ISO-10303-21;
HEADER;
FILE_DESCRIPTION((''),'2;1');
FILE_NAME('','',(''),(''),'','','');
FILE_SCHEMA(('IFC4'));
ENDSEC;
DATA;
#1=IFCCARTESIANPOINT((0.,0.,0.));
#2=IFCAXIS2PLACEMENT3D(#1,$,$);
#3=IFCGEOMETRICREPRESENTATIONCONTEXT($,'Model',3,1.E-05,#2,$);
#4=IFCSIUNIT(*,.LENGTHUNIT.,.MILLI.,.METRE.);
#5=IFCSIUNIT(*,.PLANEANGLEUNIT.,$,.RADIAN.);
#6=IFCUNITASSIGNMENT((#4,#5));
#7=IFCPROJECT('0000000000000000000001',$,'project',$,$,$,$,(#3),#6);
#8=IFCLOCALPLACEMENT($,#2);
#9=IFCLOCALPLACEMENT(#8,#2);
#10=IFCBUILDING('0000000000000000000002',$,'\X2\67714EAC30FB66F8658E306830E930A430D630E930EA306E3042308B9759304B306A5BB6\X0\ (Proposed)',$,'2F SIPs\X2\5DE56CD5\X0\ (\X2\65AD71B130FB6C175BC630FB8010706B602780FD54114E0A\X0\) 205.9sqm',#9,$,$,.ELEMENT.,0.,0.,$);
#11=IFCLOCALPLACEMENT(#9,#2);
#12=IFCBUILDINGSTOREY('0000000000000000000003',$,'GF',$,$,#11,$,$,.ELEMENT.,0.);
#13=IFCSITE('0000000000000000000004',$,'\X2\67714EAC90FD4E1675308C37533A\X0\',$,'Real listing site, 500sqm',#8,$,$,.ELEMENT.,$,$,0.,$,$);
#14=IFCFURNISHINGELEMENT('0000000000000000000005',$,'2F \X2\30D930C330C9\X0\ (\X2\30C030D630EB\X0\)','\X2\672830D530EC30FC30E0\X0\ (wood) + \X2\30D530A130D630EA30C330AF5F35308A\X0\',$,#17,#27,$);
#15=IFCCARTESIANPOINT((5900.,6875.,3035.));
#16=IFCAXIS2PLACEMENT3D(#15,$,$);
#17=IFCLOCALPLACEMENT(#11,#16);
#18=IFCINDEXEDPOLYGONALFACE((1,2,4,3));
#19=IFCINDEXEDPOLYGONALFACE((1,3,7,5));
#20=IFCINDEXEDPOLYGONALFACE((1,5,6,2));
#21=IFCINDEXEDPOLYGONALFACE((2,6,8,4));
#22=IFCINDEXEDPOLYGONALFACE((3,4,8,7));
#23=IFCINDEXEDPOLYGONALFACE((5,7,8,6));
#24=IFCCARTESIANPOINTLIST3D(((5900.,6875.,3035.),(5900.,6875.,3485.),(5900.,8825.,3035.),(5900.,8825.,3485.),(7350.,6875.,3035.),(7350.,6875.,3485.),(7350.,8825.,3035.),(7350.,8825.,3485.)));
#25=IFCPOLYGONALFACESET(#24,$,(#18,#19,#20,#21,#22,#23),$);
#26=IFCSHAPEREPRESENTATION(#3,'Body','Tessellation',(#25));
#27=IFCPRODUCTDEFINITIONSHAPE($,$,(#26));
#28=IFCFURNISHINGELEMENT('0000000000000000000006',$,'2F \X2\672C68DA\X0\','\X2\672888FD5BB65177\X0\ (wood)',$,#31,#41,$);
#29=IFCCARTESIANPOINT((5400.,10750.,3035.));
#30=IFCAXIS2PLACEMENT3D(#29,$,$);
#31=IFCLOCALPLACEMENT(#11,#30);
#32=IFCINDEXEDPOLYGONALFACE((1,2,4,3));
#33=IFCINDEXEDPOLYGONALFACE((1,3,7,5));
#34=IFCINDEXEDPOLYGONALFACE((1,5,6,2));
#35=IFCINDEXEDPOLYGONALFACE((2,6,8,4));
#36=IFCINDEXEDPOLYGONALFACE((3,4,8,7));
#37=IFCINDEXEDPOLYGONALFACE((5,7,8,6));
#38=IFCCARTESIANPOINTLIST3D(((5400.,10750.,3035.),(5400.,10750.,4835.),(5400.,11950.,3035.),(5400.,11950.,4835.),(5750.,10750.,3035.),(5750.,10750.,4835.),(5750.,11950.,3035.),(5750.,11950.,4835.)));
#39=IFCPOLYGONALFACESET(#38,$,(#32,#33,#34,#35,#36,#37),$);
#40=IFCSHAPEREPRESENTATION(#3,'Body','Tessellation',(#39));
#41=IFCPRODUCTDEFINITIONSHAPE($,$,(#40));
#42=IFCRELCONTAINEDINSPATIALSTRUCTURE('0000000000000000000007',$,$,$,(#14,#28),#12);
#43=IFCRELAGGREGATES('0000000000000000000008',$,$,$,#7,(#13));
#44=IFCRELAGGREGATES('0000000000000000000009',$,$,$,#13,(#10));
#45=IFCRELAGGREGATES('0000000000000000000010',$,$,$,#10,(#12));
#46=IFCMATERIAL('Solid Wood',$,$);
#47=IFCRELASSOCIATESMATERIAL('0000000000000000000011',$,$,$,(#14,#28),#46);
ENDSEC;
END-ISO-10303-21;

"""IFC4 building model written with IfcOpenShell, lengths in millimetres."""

from ifc_helpers import new_model, si_unit, frame, frame_2d, origin, place, context, project, spatial, rectangle, extrude, material, element, save


model = new_model("IFC4")

# Units and contexts
model_context = context("Model", 3, precision=1e-05, world=origin())
ifc_project = project(units=[si_unit("LENGTHUNIT", "METRE", prefix="MILLI"), si_unit("PLANEANGLEUNIT", "RADIAN")], contexts=[model_context])

# Site, building, storey
site_placement = place(None, origin())
site = spatial("IfcSite", under=ifc_project, at=site_placement, Name="東京都世田谷区", ObjectType="Real listing site, 500sqm", CompositionType="ELEMENT", RefElevation=0.0)
building_placement = place(site_placement, origin())
building = spatial("IfcBuilding", under=site, at=building_placement, Name="東京・書斎とライブラリのある静かな家 (Proposed)", ObjectType="2F SIPs工法 (断熱・気密・耐火性能向上) 205.9sqm", CompositionType="ELEMENT", ElevationOfRefHeight=0.0, ElevationOfTerrain=0.0)
storey_placement = place(building_placement, origin())
storey = spatial("IfcBuildingStorey", under=building, at=storey_placement, Name="GF", CompositionType="ELEMENT", Elevation=0.0)

# Shared definitions
ifc_material_1 = material(Name="Solid Wood")

# Furnishing elements
furnishing_1_placement = place(storey_placement, frame((5900.0, 6875.0, 3035.0)))
element("IfcFurnishingElement", 1, at=furnishing_1_placement, inside=storey, material=ifc_material_1, Name="2F ベッド (ダブル)", Description="木フレーム (wood) + ファブリック張り", context=model_context, shape_type="SweptSolid", body=[
    extrude(rectangle(XDim=1450.0, YDim=1950.0, at=frame_2d((725.0, 975.0))), frame((5900.0, 6875.0, 3035.0)), (0.0, 0.0, 1.0), 450.0),
])
furnishing_2_placement = place(storey_placement, frame((5400.0, 10750.0, 3035.0)))
element("IfcFurnishingElement", 2, at=furnishing_2_placement, inside=storey, material=ifc_material_1, Name="2F 本棚", Description="木製家具 (wood)", context=model_context, shape_type="SweptSolid", body=[
    extrude(rectangle(XDim=350.0, YDim=1200.0, at=frame_2d((175.0, 600.0))), frame((5400.0, 10750.0, 3035.0)), (0.0, 0.0, 1.0), 1800.0),
])

save(model, "model.ifc")
